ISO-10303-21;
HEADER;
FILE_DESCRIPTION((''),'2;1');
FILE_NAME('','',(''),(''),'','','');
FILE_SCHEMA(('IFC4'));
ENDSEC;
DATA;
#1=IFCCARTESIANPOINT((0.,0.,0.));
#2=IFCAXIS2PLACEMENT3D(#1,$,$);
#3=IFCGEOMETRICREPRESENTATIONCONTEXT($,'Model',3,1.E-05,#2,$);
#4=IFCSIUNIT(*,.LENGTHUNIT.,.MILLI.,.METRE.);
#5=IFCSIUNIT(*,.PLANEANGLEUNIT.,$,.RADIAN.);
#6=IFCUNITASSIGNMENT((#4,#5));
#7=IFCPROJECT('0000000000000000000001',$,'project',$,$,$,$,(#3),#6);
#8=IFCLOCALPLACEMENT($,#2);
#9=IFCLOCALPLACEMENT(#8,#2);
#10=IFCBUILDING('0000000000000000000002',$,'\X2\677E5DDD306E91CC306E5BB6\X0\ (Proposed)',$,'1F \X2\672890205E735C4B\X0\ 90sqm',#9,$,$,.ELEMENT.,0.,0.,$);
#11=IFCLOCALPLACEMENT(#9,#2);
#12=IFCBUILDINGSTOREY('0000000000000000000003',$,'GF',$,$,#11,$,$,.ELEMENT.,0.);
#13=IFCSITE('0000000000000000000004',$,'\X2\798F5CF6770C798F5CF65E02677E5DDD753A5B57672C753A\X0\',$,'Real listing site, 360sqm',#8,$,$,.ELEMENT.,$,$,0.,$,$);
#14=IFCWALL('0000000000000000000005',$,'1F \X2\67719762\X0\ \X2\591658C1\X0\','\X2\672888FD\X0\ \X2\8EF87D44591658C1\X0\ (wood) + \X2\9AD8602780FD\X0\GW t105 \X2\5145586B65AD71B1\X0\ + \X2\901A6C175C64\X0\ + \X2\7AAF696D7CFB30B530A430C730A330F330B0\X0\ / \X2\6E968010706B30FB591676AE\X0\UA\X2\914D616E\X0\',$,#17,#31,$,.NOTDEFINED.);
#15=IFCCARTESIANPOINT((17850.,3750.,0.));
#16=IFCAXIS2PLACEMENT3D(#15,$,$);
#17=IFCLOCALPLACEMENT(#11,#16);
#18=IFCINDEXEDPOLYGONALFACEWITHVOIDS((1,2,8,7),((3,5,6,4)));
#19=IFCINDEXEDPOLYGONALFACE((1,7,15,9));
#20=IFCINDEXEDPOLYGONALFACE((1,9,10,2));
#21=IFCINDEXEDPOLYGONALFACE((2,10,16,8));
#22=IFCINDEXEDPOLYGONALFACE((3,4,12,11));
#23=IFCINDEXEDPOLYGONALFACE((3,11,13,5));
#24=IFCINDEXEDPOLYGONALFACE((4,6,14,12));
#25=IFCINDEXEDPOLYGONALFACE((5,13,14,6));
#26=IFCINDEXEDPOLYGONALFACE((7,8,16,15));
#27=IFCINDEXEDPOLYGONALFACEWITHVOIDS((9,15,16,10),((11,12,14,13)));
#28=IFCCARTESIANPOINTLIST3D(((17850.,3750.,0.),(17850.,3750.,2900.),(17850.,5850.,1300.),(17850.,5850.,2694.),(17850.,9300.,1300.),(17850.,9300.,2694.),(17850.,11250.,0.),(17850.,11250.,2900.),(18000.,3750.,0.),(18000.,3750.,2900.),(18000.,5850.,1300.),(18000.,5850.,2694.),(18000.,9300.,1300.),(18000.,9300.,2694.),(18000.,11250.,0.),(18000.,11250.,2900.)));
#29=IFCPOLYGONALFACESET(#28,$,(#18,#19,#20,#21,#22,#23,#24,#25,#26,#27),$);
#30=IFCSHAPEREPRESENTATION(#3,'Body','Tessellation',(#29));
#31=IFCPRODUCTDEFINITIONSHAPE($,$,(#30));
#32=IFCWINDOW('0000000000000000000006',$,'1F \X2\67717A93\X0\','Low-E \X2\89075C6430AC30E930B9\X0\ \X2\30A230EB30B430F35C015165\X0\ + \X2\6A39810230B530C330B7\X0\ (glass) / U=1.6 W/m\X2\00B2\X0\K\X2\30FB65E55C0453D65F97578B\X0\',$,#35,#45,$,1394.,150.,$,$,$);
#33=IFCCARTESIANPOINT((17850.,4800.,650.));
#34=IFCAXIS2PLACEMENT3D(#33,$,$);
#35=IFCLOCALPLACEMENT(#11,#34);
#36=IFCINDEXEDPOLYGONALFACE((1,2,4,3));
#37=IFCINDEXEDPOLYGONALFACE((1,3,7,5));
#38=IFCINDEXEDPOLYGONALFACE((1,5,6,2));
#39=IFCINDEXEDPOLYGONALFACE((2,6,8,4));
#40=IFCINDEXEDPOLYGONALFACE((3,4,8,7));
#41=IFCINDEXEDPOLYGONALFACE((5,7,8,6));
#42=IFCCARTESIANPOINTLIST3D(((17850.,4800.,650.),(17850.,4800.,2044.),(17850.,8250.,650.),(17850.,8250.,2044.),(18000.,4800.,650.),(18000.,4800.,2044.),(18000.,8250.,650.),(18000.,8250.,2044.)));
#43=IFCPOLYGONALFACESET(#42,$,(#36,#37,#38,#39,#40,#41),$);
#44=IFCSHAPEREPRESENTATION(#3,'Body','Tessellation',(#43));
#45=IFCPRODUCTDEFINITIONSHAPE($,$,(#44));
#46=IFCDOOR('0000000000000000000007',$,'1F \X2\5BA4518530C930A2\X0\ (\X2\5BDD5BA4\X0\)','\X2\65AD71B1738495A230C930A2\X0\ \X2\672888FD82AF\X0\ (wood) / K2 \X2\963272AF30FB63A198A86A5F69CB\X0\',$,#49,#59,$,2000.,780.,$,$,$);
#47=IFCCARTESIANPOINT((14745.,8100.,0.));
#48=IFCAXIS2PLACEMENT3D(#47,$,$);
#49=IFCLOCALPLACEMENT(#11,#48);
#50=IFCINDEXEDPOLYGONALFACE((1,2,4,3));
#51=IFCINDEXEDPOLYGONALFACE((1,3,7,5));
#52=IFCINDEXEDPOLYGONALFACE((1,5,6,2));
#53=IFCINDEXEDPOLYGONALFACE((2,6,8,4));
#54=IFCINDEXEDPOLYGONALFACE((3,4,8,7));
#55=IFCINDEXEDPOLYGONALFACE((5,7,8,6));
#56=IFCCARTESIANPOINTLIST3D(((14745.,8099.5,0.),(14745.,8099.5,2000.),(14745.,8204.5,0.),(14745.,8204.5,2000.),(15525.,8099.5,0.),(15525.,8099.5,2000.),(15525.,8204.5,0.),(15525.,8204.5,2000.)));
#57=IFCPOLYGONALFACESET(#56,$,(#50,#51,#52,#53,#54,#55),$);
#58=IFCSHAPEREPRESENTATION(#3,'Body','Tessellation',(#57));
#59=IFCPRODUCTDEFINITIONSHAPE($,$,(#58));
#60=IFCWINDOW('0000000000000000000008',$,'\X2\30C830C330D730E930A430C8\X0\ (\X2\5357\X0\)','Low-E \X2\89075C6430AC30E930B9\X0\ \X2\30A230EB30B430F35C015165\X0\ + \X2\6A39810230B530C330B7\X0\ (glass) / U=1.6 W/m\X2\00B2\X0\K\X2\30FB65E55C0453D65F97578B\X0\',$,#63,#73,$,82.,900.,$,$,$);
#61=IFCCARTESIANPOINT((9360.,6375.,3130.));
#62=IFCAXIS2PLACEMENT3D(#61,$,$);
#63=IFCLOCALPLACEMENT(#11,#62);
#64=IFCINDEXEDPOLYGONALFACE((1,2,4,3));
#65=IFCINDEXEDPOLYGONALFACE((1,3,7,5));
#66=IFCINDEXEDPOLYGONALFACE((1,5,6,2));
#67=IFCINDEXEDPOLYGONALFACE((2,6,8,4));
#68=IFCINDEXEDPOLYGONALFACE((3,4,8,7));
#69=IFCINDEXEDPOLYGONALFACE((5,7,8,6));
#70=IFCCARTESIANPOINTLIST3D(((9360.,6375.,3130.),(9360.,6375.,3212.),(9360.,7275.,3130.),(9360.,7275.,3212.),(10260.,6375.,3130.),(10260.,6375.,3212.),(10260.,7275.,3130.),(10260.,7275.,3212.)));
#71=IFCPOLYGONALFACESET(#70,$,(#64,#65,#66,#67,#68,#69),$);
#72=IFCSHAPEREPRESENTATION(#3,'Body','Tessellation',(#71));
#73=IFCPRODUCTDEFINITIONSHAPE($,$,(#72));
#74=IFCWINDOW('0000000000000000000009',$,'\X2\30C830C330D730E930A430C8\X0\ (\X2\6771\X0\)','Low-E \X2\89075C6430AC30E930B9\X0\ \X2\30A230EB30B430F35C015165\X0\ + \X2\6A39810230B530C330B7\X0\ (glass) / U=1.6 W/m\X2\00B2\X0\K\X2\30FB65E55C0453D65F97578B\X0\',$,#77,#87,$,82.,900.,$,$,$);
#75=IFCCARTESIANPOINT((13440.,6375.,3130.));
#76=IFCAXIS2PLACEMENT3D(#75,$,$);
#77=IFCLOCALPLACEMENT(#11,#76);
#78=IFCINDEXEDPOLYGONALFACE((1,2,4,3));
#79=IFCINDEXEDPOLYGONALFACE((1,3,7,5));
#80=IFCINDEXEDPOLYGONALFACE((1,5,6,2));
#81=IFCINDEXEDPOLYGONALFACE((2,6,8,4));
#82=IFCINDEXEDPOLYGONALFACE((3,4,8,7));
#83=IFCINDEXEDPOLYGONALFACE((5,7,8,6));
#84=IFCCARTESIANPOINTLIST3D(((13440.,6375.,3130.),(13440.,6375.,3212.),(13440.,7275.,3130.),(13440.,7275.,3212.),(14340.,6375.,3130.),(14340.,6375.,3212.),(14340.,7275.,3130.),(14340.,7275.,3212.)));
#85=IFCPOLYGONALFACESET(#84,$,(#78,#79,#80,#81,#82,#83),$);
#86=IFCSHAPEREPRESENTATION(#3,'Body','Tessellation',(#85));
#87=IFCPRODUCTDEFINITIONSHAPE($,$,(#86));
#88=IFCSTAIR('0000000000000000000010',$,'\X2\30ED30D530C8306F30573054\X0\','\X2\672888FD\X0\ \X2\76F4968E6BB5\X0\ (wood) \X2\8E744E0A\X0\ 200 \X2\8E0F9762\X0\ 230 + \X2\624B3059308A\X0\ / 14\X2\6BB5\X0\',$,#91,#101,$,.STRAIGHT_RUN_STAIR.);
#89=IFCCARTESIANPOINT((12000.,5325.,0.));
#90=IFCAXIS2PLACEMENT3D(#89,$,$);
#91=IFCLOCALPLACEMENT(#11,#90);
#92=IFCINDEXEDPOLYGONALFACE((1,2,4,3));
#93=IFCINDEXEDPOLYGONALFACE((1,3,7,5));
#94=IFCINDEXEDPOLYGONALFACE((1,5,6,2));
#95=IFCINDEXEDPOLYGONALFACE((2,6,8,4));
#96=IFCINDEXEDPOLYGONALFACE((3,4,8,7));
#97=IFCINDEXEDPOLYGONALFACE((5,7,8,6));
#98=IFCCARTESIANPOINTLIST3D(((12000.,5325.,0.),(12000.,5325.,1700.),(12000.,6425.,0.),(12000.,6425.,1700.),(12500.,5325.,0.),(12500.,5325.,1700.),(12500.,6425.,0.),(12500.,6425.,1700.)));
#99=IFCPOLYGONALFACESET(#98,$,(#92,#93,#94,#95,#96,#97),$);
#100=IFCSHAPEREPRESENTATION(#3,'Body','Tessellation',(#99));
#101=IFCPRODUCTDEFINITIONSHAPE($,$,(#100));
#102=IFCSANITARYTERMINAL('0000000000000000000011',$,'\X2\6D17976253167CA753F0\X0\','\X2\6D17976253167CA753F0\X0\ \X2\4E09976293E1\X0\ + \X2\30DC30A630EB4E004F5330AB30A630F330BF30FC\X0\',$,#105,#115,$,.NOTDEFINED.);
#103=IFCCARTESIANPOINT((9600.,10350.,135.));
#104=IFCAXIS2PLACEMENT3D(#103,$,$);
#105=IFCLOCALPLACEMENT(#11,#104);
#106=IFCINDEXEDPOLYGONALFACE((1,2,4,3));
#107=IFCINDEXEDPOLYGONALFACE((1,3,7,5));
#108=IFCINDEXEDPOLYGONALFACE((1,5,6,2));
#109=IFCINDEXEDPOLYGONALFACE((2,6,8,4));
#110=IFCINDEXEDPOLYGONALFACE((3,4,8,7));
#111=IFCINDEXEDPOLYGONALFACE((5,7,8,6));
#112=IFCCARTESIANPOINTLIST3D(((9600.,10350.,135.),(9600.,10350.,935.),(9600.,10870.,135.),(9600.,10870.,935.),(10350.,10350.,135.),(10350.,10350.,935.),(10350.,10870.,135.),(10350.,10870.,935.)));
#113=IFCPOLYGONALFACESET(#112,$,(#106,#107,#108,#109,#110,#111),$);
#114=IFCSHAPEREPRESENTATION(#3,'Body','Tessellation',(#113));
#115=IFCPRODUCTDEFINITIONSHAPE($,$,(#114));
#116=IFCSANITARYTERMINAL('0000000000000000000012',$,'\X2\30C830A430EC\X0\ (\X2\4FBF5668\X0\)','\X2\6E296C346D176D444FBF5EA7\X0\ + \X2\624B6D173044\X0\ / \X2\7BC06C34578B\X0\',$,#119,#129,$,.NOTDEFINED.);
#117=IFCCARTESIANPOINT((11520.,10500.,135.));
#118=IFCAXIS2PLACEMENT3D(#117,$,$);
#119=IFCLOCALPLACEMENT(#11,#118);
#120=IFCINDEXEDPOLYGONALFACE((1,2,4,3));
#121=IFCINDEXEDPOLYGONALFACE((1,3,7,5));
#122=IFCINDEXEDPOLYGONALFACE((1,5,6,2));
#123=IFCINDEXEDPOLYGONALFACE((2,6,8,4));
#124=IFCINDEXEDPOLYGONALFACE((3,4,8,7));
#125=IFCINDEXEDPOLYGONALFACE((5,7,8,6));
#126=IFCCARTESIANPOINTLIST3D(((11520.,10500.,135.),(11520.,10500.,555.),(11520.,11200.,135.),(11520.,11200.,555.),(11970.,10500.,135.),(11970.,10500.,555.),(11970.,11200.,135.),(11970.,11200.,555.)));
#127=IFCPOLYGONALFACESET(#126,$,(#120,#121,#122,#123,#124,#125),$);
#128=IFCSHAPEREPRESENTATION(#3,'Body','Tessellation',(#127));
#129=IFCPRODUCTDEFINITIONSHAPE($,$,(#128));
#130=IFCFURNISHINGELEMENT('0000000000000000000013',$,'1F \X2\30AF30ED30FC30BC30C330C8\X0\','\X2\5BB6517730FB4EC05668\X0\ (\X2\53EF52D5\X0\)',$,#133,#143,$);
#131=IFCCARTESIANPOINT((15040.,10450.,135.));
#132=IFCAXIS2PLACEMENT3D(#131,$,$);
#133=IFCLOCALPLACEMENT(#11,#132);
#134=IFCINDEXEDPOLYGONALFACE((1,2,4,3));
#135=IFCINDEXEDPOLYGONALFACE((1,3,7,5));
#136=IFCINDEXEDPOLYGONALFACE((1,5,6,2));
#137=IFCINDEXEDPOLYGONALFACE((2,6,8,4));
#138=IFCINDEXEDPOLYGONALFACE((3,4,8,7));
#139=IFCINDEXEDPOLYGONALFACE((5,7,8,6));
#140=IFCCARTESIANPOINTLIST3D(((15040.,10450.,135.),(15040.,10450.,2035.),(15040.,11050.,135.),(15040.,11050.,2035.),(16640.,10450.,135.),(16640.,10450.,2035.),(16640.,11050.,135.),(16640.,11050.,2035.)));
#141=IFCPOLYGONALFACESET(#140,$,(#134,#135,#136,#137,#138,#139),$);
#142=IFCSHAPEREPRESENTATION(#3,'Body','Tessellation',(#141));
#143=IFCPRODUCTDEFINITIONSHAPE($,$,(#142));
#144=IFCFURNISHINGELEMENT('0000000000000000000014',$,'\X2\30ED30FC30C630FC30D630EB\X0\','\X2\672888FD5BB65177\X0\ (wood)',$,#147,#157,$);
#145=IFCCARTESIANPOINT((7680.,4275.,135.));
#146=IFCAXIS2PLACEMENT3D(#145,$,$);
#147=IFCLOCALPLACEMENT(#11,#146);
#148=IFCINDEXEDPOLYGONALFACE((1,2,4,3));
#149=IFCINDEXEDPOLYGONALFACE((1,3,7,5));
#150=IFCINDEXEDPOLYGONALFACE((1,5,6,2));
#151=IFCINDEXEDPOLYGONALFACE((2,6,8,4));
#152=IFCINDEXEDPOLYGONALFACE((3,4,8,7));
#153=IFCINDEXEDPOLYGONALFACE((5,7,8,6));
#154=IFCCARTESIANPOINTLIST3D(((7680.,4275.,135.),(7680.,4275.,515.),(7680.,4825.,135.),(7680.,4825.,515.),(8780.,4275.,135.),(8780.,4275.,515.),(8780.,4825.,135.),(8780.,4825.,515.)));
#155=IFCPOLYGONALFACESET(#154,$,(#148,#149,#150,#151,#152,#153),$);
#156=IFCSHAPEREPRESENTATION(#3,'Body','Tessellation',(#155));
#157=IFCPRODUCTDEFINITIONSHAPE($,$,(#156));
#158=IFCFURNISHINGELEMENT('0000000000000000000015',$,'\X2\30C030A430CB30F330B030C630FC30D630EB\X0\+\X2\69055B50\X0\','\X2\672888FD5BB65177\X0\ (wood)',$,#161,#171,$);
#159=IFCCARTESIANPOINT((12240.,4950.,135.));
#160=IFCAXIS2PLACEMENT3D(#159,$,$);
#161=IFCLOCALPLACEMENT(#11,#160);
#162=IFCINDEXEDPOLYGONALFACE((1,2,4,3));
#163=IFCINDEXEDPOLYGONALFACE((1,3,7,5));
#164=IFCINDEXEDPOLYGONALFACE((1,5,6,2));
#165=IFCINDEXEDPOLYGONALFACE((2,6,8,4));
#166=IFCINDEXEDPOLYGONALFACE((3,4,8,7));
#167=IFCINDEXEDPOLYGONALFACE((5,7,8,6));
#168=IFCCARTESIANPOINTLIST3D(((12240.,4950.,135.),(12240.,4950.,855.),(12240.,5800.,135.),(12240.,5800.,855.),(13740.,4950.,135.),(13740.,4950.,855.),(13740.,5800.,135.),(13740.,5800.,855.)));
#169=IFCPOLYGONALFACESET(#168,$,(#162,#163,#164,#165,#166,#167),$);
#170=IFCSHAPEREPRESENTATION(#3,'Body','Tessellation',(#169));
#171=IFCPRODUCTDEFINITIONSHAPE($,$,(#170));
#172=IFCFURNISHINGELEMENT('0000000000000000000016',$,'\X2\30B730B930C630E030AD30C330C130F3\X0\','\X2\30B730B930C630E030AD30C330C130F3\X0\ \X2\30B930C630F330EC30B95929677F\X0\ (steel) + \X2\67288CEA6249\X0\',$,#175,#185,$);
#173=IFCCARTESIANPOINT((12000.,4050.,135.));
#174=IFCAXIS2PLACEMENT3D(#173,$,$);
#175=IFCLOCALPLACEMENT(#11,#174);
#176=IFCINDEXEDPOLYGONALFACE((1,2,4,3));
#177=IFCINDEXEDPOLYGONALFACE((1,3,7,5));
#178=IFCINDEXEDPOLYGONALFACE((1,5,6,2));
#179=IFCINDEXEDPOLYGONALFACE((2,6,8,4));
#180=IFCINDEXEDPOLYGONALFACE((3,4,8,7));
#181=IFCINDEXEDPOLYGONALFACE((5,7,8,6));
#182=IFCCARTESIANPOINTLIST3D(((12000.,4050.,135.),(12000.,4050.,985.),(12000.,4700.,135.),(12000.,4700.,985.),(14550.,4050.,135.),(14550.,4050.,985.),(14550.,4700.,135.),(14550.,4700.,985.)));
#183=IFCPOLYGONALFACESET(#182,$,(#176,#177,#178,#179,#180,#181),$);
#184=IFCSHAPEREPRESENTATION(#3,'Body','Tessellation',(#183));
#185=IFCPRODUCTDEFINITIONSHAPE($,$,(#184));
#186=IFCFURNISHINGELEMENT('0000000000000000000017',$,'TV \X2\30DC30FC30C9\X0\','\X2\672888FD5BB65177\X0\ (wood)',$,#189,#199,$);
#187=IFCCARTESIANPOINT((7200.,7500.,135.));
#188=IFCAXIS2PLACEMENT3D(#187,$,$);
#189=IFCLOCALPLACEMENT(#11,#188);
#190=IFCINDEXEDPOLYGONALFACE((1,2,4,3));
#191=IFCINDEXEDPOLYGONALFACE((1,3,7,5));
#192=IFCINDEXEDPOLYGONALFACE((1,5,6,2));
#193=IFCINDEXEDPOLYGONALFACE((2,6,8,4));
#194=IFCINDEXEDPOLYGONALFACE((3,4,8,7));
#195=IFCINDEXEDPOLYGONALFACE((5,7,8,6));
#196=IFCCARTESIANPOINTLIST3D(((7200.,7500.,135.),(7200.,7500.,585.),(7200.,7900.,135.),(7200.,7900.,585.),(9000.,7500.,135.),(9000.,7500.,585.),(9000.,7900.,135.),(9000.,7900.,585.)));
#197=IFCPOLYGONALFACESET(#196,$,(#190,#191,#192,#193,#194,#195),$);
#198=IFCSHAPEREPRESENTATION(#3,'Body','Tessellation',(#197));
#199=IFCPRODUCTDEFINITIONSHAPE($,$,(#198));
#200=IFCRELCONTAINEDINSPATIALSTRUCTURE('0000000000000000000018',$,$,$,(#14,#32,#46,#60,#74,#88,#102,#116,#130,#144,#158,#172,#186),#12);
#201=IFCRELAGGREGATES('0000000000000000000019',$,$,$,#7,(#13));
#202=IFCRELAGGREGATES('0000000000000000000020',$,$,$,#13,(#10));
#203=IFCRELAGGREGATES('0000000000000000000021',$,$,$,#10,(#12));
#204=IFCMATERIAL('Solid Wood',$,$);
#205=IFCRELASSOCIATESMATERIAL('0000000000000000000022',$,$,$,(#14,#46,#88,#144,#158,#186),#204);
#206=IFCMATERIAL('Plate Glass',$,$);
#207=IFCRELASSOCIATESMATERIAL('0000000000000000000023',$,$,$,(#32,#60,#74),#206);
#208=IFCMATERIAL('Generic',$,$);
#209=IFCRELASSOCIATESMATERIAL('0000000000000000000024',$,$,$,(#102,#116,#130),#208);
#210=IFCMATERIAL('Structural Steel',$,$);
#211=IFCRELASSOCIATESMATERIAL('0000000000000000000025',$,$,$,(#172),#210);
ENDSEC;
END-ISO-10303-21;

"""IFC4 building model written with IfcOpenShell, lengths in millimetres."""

from ifc_helpers import new_model, si_unit, frame, frame_2d, origin, place, context, project, spatial, rectangle, extrude, material, element, fill, save


model = new_model("IFC4")

# Units and contexts
model_context = context("Model", 3, precision=1e-05, world=origin())
ifc_project = project(units=[si_unit("LENGTHUNIT", "METRE", prefix="MILLI"), si_unit("PLANEANGLEUNIT", "RADIAN")], contexts=[model_context])

# Site, building, storey
site_placement = place(None, origin())
site = spatial("IfcSite", under=ifc_project, at=site_placement, Name="福島県福島市松川町字本町", ObjectType="Real listing site, 360sqm", CompositionType="ELEMENT", RefElevation=0.0)
building_placement = place(site_placement, origin())
building = spatial("IfcBuilding", under=site, at=building_placement, Name="松川の里の家 (Proposed)", ObjectType="1F 木造平屋 90sqm", CompositionType="ELEMENT", ElevationOfRefHeight=0.0, ElevationOfTerrain=0.0)
storey_placement = place(building_placement, origin())
storey = spatial("IfcBuildingStorey", under=building, at=storey_placement, Name="GF", CompositionType="ELEMENT", Elevation=0.0)

# Wall, opening, window
ifc_material_1 = material(Name="Solid Wood")
wall_1_placement = place(storey_placement, frame((17850.0, 3750.0, 0.0)))
wall_1 = element("IfcWall", 1, at=wall_1_placement, inside=storey, material=ifc_material_1, Name="1F 東面 外壁", Description="木製 軸組外壁 (wood) + 高性能GW t105 充填断熱 + 通気層 + 窯業系サイディング / 準耐火・外皮UA配慮", PredefinedType="NOTDEFINED", context=model_context, shape_type="SweptSolid", body=[
    extrude(rectangle(XDim=150.0, YDim=7500.0, at=frame_2d((75.0, 3750.0))), frame((17850.0, 3750.0, 0.0)), (0.0, 0.0, 1.0), 2900.0),
])
opening_placement = place(storey_placement, frame((17850.0, 4800.0, 650.0)))
opening = element("IfcOpeningElement", 2, at=opening_placement, cuts=wall_1, PredefinedType="NOTDEFINED", context=model_context, shape_type="SweptSolid", body=[
    extrude(rectangle(XDim=150.0, YDim=3450.0, at=frame_2d((75.0, 1725.0))), frame((17850.0, 4800.0, 650.0)), (0.0, 0.0, 1.0), 1394.0),
])
ifc_material_2 = material(Name="Plate Glass")
window_1_placement = place(storey_placement, frame((17850.0, 4800.0, 650.0)))
window_1 = element("IfcWindow", 3, at=window_1_placement, inside=storey, material=ifc_material_2, Name="1F 東窓", Description="Low-E 複層ガラス アルゴン封入 + 樹脂サッシ (glass) / U=1.6 W/m²K・日射取得型", OverallHeight=1394.0, OverallWidth=150.0, context=model_context, shape_type="SweptSolid", body=[
    extrude(rectangle(XDim=150.0, YDim=3450.0, at=frame_2d((75.0, 1725.0))), frame((17850.0, 4800.0, 650.0)), (0.0, 0.0, 1.0), 1394.0),
])
fill(opening, window_1)

# Door
door_placement = place(storey_placement, frame((14745.0, 8100.0, 0.0)))
element("IfcDoor", 4, at=door_placement, inside=storey, material=ifc_material_1, Name="1F 室内ドア (寝室)", Description="断熱玄関ドア 木製芯 (wood) / K2 防犯・採風機構", OverallHeight=2000.0, OverallWidth=780.0, context=model_context, shape_type="SweptSolid", body=[
    extrude(rectangle(XDim=780.0, YDim=105.0, at=frame_2d((390.0, 52.0))), frame((14745.0, 8100.0, 0.0)), (0.0, 0.0, 1.0), 2000.0),
])

# Windows
window_2_placement = place(storey_placement, frame((9360.0, 6375.0, 3130.0)))
element("IfcWindow", 5, at=window_2_placement, inside=storey, material=ifc_material_2, Name="トップライト (南)", Description="Low-E 複層ガラス アルゴン封入 + 樹脂サッシ (glass) / U=1.6 W/m²K・日射取得型", OverallHeight=82.0, OverallWidth=900.0, context=model_context, shape_type="SweptSolid", body=[
    extrude(rectangle(XDim=900.0, YDim=900.0, at=frame_2d((450.0, 450.0))), frame((9360.0, 6375.0, 3130.0)), (0.0, 0.0, 1.0), 82.0),
])
window_3_placement = place(storey_placement, frame((13440.0, 6375.0, 3130.0)))
element("IfcWindow", 6, at=window_3_placement, inside=storey, material=ifc_material_2, Name="トップライト (東)", Description="Low-E 複層ガラス アルゴン封入 + 樹脂サッシ (glass) / U=1.6 W/m²K・日射取得型", OverallHeight=82.0, OverallWidth=900.0, context=model_context, shape_type="SweptSolid", body=[
    extrude(rectangle(XDim=900.0, YDim=900.0, at=frame_2d((450.0, 450.0))), frame((13440.0, 6375.0, 3130.0)), (0.0, 0.0, 1.0), 82.0),
])

# Stair
stair_placement = place(storey_placement, frame((12000.0, 5325.0, 0.0)))
element("IfcStair", 7, at=stair_placement, inside=storey, material=ifc_material_1, Name="ロフトはしご", Description="木製 直階段 (wood) 蹴上 200 踏面 230 + 手すり / 14段", PredefinedType="STRAIGHT_RUN_STAIR", context=model_context, shape_type="SweptSolid", body=[
    extrude(rectangle(XDim=500.0, YDim=1100.0, at=frame_2d((250.0, 550.0))), frame((12000.0, 5325.0, 0.0)), (0.0, 0.0, 1.0), 1700.0),
])

# Sanitary terminals
ifc_material_3 = material(Name="Generic")
sanitary_terminal_1_placement = place(storey_placement, frame((9600.0, 10350.0, 135.0)))
element("IfcSanitaryTerminal", 8, at=sanitary_terminal_1_placement, inside=storey, material=ifc_material_3, Name="洗面化粧台", Description="洗面化粧台 三面鏡 + ボウル一体カウンター", PredefinedType="NOTDEFINED", context=model_context, shape_type="SweptSolid", body=[
    extrude(rectangle(XDim=750.0, YDim=520.0, at=frame_2d((375.0, 260.0))), frame((9600.0, 10350.0, 135.0)), (0.0, 0.0, 1.0), 800.0),
])
sanitary_terminal_2_placement = place(storey_placement, frame((11520.0, 10500.0, 135.0)))
element("IfcSanitaryTerminal", 9, at=sanitary_terminal_2_placement, inside=storey, material=ifc_material_3, Name="トイレ (便器)", Description="温水洗浄便座 + 手洗い / 節水型", PredefinedType="NOTDEFINED", context=model_context, shape_type="SweptSolid", body=[
    extrude(rectangle(XDim=450.0, YDim=700.0, at=frame_2d((225.0, 350.0))), frame((11520.0, 10500.0, 135.0)), (0.0, 0.0, 1.0), 420.0),
])

# Furnishing elements
furnishing_1_placement = place(storey_placement, frame((15040.0, 10450.0, 135.0)))
element("IfcFurnishingElement", 10, at=furnishing_1_placement, inside=storey, material=ifc_material_3, Name="1F クローゼット", Description="家具・什器 (可動)", context=model_context, shape_type="SweptSolid", body=[
    extrude(rectangle(XDim=1600.0, YDim=600.0, at=frame_2d((800.0, 300.0))), frame((15040.0, 10450.0, 135.0)), (0.0, 0.0, 1.0), 1900.0),
])
furnishing_2_placement = place(storey_placement, frame((7680.0, 4275.0, 135.0)))
element("IfcFurnishingElement", 11, at=furnishing_2_placement, inside=storey, material=ifc_material_1, Name="ローテーブル", Description="木製家具 (wood)", context=model_context, shape_type="SweptSolid", body=[
    extrude(rectangle(XDim=1100.0, YDim=550.0, at=frame_2d((550.0, 275.0))), frame((7680.0, 4275.0, 135.0)), (0.0, 0.0, 1.0), 380.0),
])
furnishing_3_placement = place(storey_placement, frame((12240.0, 4950.0, 135.0)))
element("IfcFurnishingElement", 12, at=furnishing_3_placement, inside=storey, material=ifc_material_1, Name="ダイニングテーブル+椅子", Description="木製家具 (wood)", context=model_context, shape_type="SweptSolid", body=[
    extrude(rectangle(XDim=1500.0, YDim=850.0, at=frame_2d((750.0, 425.0))), frame((12240.0, 4950.0, 135.0)), (0.0, 0.0, 1.0), 720.0),
])
ifc_material_4 = material(Name="Structural Steel")
furnishing_4_placement = place(storey_placement, frame((12000.0, 4050.0, 135.0)))
element("IfcFurnishingElement", 13, at=furnishing_4_placement, inside=storey, material=ifc_material_4, Name="システムキッチン", Description="システムキッチン ステンレス天板 (steel) + 木質扉", context=model_context, shape_type="SweptSolid", body=[
    extrude(rectangle(XDim=2550.0, YDim=650.0, at=frame_2d((1275.0, 325.0))), frame((12000.0, 4050.0, 135.0)), (0.0, 0.0, 1.0), 850.0),
])
furnishing_5_placement = place(storey_placement, frame((7200.0, 7500.0, 135.0)))
element("IfcFurnishingElement", 14, at=furnishing_5_placement, inside=storey, material=ifc_material_1, Name="TV ボード", Description="木製家具 (wood)", context=model_context, shape_type="SweptSolid", body=[
    extrude(rectangle(XDim=1800.0, YDim=400.0, at=frame_2d((900.0, 200.0))), frame((7200.0, 7500.0, 135.0)), (0.0, 0.0, 1.0), 450.0),
])

save(model, "model.ifc")
